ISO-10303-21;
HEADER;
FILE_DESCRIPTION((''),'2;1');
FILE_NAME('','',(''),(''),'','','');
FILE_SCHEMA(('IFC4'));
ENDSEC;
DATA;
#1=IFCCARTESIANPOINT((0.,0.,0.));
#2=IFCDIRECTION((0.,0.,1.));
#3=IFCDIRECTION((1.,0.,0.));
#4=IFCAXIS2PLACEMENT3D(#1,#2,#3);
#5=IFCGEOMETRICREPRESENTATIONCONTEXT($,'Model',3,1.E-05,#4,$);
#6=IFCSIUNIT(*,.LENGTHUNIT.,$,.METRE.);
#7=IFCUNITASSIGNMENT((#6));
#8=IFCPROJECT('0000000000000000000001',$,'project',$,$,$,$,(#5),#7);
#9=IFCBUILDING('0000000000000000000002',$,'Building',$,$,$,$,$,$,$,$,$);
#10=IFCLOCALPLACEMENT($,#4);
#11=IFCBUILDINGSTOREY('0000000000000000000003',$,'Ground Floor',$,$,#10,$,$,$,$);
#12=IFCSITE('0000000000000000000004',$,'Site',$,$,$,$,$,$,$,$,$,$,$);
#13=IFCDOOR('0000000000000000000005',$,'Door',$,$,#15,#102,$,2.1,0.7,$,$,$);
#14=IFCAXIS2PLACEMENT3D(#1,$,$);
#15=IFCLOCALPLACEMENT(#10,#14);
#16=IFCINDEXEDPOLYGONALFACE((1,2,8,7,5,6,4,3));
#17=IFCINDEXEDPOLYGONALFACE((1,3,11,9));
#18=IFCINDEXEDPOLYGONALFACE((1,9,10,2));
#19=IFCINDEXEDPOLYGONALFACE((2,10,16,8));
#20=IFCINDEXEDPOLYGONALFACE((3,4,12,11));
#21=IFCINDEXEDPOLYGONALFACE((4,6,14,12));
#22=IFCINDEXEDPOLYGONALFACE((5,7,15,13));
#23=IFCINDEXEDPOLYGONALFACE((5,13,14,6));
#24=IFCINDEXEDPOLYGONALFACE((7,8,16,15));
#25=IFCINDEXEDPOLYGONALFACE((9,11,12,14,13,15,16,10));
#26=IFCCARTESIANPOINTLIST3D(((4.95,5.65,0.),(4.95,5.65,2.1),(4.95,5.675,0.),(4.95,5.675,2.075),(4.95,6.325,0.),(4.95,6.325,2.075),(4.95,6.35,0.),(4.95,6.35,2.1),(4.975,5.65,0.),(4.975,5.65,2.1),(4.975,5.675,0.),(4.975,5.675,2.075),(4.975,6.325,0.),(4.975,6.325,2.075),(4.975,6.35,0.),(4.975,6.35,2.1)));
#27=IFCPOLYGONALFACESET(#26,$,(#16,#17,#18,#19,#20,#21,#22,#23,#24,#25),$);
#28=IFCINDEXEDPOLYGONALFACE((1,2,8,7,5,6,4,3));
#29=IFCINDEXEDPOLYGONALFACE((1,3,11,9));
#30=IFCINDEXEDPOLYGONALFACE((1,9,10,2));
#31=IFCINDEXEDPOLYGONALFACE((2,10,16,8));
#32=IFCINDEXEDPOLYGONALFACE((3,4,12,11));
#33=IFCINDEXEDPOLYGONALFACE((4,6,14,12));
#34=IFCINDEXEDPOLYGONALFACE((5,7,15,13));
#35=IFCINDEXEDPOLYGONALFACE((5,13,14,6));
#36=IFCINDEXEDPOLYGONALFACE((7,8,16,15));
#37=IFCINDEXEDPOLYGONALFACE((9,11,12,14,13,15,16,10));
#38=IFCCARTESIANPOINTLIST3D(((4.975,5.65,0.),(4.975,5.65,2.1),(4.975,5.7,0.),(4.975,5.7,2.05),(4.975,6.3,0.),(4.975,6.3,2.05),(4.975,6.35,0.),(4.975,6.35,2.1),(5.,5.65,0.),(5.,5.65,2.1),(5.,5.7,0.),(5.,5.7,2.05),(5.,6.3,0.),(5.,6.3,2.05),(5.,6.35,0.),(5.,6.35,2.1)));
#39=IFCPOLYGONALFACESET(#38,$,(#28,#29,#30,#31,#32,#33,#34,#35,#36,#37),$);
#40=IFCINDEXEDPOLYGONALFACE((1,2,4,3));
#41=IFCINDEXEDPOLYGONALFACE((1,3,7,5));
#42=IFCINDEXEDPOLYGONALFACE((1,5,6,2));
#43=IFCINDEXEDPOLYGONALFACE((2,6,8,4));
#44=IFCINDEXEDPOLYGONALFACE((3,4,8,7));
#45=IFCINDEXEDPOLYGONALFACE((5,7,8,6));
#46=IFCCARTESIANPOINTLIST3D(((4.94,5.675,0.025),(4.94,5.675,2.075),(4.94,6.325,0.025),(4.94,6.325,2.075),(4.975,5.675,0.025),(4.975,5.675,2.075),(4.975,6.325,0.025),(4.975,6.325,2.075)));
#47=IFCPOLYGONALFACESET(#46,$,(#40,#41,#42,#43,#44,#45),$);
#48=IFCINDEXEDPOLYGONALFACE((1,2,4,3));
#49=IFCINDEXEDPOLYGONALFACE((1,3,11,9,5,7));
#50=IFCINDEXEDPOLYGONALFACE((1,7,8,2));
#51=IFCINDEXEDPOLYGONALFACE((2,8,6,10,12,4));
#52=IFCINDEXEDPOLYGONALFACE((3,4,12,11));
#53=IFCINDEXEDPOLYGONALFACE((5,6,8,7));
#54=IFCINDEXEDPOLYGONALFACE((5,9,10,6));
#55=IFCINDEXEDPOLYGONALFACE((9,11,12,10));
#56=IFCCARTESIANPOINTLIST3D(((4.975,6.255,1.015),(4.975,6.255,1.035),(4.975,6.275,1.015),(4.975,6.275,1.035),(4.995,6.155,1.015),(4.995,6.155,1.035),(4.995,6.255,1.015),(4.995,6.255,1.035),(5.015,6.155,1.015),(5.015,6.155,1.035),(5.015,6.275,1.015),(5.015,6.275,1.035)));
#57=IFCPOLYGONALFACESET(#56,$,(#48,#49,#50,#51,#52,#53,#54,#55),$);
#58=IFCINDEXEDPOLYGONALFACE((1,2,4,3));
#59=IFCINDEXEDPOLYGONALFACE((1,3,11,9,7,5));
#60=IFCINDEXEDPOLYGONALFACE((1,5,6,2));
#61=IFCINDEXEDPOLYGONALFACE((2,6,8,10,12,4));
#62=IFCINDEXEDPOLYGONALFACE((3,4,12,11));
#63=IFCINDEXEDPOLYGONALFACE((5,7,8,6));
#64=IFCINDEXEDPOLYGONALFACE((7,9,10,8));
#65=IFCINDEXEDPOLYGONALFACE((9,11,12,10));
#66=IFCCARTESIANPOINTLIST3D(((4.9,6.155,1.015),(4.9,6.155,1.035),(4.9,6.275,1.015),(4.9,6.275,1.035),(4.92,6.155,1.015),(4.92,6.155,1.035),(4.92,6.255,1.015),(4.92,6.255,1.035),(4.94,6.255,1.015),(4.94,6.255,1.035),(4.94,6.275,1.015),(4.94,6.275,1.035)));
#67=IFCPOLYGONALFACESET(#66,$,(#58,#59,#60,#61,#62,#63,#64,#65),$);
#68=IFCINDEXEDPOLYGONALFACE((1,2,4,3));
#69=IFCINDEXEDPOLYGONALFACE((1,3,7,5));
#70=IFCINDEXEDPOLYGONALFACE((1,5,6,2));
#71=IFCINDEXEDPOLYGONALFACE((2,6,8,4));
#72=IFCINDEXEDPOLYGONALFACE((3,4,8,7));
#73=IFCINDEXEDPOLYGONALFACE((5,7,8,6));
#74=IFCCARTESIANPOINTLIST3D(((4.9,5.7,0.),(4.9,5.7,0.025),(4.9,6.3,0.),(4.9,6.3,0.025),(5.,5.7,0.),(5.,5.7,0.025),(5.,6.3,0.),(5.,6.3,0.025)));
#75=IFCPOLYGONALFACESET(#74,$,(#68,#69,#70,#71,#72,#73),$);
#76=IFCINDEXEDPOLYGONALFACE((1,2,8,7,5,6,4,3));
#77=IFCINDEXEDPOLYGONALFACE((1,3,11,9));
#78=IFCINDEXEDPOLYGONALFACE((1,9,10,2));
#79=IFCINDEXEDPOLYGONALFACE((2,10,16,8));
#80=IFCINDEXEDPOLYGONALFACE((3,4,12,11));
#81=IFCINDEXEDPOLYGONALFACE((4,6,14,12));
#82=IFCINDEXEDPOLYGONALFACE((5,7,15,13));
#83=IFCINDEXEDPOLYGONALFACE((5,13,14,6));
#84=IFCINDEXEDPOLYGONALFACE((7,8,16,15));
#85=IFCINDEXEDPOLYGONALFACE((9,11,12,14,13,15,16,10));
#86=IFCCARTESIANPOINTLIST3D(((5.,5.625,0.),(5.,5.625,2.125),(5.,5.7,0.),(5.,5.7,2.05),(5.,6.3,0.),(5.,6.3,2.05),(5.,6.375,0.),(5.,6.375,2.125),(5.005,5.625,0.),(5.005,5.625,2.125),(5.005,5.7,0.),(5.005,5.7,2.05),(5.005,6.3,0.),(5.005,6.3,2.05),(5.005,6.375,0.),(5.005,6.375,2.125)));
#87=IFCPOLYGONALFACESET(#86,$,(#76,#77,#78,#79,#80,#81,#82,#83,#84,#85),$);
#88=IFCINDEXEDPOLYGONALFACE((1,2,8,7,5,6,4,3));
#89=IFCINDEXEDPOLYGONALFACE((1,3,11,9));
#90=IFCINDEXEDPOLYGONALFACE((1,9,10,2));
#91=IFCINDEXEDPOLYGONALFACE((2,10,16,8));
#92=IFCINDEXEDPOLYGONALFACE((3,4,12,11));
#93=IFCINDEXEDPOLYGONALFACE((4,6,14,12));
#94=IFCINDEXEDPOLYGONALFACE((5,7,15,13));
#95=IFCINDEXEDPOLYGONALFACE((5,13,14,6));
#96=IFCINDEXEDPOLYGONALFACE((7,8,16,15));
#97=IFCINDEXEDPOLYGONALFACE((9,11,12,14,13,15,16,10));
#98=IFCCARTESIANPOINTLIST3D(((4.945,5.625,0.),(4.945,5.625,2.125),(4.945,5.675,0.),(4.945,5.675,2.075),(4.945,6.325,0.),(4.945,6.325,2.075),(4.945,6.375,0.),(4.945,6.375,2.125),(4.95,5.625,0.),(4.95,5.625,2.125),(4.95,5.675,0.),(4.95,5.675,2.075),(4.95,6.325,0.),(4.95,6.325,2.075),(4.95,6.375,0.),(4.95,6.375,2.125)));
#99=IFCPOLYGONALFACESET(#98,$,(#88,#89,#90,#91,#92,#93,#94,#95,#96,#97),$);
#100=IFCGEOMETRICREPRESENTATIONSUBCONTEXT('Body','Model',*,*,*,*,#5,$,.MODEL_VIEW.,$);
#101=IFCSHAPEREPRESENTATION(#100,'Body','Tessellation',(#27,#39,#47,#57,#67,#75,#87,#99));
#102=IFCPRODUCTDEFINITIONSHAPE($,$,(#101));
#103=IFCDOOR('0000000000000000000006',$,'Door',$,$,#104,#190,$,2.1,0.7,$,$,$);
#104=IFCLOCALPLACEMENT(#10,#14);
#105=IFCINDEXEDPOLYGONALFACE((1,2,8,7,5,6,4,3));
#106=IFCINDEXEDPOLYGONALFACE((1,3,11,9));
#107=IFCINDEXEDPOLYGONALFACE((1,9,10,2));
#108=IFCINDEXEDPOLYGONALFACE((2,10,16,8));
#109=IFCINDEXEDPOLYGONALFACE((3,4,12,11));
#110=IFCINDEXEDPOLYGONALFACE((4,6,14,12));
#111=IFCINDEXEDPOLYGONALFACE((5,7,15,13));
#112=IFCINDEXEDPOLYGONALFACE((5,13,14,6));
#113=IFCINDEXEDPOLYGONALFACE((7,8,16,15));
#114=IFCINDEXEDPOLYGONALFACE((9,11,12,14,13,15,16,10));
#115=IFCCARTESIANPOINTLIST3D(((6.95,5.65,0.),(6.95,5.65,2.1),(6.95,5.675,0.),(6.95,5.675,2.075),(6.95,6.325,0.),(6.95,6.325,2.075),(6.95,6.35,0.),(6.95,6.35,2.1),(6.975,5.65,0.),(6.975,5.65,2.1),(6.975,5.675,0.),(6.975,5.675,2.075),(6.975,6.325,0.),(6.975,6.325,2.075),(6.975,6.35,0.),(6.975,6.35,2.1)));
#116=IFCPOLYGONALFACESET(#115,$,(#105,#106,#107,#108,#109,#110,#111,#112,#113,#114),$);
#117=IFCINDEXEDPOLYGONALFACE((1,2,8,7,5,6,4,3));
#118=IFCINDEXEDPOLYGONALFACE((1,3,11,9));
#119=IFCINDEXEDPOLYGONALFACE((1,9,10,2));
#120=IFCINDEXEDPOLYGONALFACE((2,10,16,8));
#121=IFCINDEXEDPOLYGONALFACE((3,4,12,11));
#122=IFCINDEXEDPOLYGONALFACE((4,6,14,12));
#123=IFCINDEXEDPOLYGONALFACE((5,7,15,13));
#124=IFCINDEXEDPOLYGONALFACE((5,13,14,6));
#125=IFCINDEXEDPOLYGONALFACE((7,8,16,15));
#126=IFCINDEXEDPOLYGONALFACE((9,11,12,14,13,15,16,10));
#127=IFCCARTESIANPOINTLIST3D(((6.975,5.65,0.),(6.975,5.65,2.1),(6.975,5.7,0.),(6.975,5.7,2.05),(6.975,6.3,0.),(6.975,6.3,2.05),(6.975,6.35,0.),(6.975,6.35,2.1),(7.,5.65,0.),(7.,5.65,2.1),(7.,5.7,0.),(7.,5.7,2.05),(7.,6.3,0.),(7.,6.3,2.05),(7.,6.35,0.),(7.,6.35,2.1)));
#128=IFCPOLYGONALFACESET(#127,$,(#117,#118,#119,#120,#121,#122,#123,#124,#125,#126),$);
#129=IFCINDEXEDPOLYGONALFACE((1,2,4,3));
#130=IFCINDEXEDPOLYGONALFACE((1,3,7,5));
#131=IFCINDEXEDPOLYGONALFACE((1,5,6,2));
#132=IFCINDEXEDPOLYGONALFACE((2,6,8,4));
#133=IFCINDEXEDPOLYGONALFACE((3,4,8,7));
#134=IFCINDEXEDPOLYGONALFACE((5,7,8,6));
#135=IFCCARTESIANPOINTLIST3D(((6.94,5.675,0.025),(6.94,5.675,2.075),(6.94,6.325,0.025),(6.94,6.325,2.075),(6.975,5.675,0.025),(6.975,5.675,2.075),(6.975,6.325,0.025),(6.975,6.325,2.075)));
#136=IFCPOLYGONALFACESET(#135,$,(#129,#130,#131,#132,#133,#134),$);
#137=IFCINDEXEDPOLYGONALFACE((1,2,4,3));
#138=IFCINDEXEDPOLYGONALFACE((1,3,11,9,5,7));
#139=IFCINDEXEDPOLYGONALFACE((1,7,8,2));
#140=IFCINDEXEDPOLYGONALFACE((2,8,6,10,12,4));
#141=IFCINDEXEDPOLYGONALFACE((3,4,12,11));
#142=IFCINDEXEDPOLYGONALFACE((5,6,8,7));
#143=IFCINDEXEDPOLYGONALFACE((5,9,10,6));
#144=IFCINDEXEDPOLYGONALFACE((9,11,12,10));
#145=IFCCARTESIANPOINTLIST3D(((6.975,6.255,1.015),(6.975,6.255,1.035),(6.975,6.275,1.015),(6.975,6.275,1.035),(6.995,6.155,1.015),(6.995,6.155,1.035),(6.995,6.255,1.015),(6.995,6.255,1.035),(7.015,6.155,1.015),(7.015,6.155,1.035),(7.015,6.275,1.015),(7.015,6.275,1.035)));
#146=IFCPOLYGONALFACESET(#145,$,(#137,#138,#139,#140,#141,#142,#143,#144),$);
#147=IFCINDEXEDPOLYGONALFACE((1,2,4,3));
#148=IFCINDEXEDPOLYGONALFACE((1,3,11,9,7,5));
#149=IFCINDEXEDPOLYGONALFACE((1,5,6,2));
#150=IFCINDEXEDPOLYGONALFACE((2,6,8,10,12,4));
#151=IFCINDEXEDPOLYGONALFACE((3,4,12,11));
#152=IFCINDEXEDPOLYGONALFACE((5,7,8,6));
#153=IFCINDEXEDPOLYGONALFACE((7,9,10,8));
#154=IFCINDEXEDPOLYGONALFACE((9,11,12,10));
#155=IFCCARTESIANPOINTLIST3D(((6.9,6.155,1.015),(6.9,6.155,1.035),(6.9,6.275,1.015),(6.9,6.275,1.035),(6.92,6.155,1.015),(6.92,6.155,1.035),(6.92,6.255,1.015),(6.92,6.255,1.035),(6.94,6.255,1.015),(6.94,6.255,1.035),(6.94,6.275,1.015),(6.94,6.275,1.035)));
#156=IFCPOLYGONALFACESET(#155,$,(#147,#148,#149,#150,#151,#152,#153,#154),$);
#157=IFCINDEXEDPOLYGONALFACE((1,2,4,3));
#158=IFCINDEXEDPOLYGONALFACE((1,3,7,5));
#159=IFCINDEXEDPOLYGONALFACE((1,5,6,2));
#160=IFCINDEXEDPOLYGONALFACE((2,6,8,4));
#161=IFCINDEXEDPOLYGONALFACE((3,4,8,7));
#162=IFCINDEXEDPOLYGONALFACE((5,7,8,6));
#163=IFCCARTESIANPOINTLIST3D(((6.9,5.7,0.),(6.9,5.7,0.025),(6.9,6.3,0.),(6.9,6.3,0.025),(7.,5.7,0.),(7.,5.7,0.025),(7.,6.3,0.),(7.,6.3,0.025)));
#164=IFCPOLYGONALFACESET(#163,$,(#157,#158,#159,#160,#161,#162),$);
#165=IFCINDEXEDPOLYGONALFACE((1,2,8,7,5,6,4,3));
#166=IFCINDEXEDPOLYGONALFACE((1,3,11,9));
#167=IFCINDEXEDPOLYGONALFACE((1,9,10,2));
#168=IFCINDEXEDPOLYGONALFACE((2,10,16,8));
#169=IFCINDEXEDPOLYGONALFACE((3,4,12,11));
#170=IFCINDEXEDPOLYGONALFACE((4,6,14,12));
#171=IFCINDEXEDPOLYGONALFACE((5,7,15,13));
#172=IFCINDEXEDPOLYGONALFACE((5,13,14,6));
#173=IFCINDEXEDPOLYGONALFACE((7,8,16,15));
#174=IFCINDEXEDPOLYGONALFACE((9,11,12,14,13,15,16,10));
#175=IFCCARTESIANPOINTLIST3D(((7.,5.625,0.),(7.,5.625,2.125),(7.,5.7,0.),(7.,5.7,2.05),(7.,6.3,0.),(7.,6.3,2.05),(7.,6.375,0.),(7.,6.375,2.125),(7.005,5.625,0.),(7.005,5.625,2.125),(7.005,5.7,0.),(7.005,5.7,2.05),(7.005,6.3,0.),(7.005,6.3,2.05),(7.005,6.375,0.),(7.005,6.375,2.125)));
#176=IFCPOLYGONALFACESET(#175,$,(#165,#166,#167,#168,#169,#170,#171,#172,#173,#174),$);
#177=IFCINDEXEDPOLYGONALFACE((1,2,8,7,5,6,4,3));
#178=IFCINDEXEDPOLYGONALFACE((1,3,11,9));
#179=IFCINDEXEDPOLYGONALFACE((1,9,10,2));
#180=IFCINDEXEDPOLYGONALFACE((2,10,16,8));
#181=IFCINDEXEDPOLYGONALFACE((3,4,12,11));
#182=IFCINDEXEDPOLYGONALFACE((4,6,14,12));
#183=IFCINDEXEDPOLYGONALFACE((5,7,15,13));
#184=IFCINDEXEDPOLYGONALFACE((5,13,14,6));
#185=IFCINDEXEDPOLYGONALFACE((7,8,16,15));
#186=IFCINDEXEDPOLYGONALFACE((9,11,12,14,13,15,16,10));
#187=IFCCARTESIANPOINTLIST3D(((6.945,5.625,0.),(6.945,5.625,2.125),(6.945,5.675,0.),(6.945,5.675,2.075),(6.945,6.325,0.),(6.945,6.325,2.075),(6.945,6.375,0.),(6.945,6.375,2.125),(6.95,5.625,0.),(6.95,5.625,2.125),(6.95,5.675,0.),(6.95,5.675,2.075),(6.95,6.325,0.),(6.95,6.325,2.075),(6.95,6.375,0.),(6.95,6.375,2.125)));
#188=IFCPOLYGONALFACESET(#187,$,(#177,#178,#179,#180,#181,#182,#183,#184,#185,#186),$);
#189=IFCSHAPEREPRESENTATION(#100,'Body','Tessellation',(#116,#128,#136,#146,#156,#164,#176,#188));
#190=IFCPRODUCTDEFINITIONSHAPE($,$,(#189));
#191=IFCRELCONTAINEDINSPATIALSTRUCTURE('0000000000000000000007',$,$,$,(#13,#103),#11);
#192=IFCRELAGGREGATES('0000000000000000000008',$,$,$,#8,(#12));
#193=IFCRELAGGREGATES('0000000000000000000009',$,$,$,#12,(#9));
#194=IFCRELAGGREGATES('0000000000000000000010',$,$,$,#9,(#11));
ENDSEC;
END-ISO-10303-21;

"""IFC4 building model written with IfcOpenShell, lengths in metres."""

from ifc_helpers import new_model, si_unit, frame, origin_with_axes, place, context, subcontext, project, spatial, line, indexed_curve, outline, extrude, element, save


model = new_model("IFC4")

# Units and contexts
model_context = context("Model", 3, precision=1e-05, world=origin_with_axes())
body_context = subcontext(model_context, "Body", "Model", "MODEL_VIEW")
ifc_project = project(units=[si_unit("LENGTHUNIT", "METRE")], contexts=[model_context])

# Site, building, storey
site = spatial("IfcSite", under=ifc_project, Name="Site")
building = spatial("IfcBuilding", under=site, Name="Building")
storey_placement = place(None, origin_with_axes())
storey = spatial("IfcBuildingStorey", under=building, at=storey_placement, Name="Ground Floor")

# Doors
door_1_placement = place(storey_placement, frame((5.0, 5.65, 0.0), z_axis=(0.0, 0.0, 1.0), x_axis=(0.0, 1.0, 0.0)))
element("IfcDoor", 1, at=door_1_placement, inside=storey, Name="Door", OverallHeight=2.1, OverallWidth=0.7, context=body_context, shape_type="SweptSolid", body=[
    extrude(outline(indexed_curve([(0.0, 0.0), (0.0, 2.1), (0.7, 2.1), (0.7, 0.0), (0.675, 0.0), (0.675, 2.075), (0.025, 2.075), (0.025, 0.0)], segments=[line(1, 2, 3, 4, 5, 6, 7, 8, 1)])), frame((0.0, 0.025, 0.0), z_axis=(0.0, -1.0, 0.0), x_axis=(1.0, 0.0, 0.0)), (0.0, 0.0, -1.0), 0.025),
    extrude(outline(indexed_curve([(0.0, 0.0), (0.0, 2.1), (0.7, 2.1), (0.7, 0.0), (0.65, 0.0), (0.65, 2.05), (0.05, 2.05), (0.05, 0.0)], segments=[line(1, 2, 3, 4, 5, 6, 7, 8, 1)])), frame((0.0, 0.0, 0.0), z_axis=(0.0, -1.0, 0.0), x_axis=(1.0, 0.0, 0.0)), (0.0, 0.0, -1.0), 0.025),
    extrude(outline(indexed_curve([(0.0, 0.0), (0.65, 0.0), (0.65, 0.035), (0.0, 0.035)], segments=[line(1, 2, 3, 4, 1)])), frame((0.025, 0.025, 0.025), z_axis=(0.0, 0.0, 1.0), x_axis=(1.0, 0.0, 0.0)), (0.0, 0.0, 1.0), 2.05),
    extrude(outline(indexed_curve([(0.0, 0.0), (0.0, -0.04), (-0.12, -0.04), (-0.12, -0.02), (-0.02, -0.02), (-0.02, 0.0)], segments=[line(1, 2, 3, 4, 5, 6, 1)])), frame((0.625, 0.025, 1.015), z_axis=(0.0, 0.0, 1.0), x_axis=(1.0, 0.0, 0.0)), (0.0, 0.0, 1.0), 0.02),
    extrude(outline(indexed_curve([(0.0, 0.0), (0.0, 0.04), (-0.12, 0.04), (-0.12, 0.02), (-0.02, 0.02), (-0.02, 0.0)], segments=[line(1, 2, 3, 4, 5, 6, 1)])), frame((0.625, 0.06, 1.015), z_axis=(0.0, 0.0, 1.0), x_axis=(1.0, 0.0, 0.0)), (0.0, 0.0, 1.0), 0.02),
    extrude(outline(indexed_curve([(0.0, 0.0), (0.6, 0.0), (0.6, 0.1), (0.0, 0.1)], segments=[line(1, 2, 3, 4, 1)])), frame((0.05, 0.0, 0.0), z_axis=(0.0, 0.0, 1.0), x_axis=(1.0, 0.0, 0.0)), (0.0, 0.0, 1.0), 0.025),
    extrude(outline(indexed_curve([(0.0, 0.0), (0.0, 2.125), (0.75, 2.125), (0.75, 0.0), (0.675, 0.0), (0.675, 2.05), (0.075, 2.05), (0.075, 0.0)], segments=[line(1, 2, 3, 4, 5, 6, 7, 8, 1)])), frame((-0.025, -0.005, 0.0), z_axis=(0.0, -1.0, 0.0), x_axis=(1.0, 0.0, 0.0)), (0.0, 0.0, -1.0), 0.005),
    extrude(outline(indexed_curve([(0.0, 0.0), (0.0, 2.125), (0.75, 2.125), (0.75, 0.0), (0.7, 0.0), (0.7, 2.075), (0.05, 2.075), (0.05, 0.0)], segments=[line(1, 2, 3, 4, 5, 6, 7, 8, 1)])), frame((-0.025, 0.05, 0.0), z_axis=(0.0, -1.0, 0.0), x_axis=(1.0, 0.0, 0.0)), (0.0, 0.0, -1.0), 0.005),
])
door_2_placement = place(storey_placement, frame((7.0, 5.65, 0.0), z_axis=(0.0, 0.0, 1.0), x_axis=(0.0, 1.0, 0.0)))
element("IfcDoor", 2, at=door_2_placement, inside=storey, Name="Door", OverallHeight=2.1, OverallWidth=0.7, context=body_context, shape_type="SweptSolid", body=[
    extrude(outline(indexed_curve([(0.0, 0.0), (0.0, 2.1), (0.7, 2.1), (0.7, 0.0), (0.675, 0.0), (0.675, 2.075), (0.025, 2.075), (0.025, 0.0)], segments=[line(1, 2, 3, 4, 5, 6, 7, 8, 1)])), frame((0.0, 0.025, 0.0), z_axis=(0.0, -1.0, 0.0), x_axis=(1.0, 0.0, 0.0)), (0.0, 0.0, -1.0), 0.025),
    extrude(outline(indexed_curve([(0.0, 0.0), (0.0, 2.1), (0.7, 2.1), (0.7, 0.0), (0.65, 0.0), (0.65, 2.05), (0.05, 2.05), (0.05, 0.0)], segments=[line(1, 2, 3, 4, 5, 6, 7, 8, 1)])), frame((0.0, 0.0, 0.0), z_axis=(0.0, -1.0, 0.0), x_axis=(1.0, 0.0, 0.0)), (0.0, 0.0, -1.0), 0.025),
    extrude(outline(indexed_curve([(0.0, 0.0), (0.65, 0.0), (0.65, 0.035), (0.0, 0.035)], segments=[line(1, 2, 3, 4, 1)])), frame((0.025, 0.025, 0.025), z_axis=(0.0, 0.0, 1.0), x_axis=(1.0, 0.0, 0.0)), (0.0, 0.0, 1.0), 2.05),
    extrude(outline(indexed_curve([(0.0, 0.0), (0.0, -0.04), (-0.12, -0.04), (-0.12, -0.02), (-0.02, -0.02), (-0.02, 0.0)], segments=[line(1, 2, 3, 4, 5, 6, 1)])), frame((0.625, 0.025, 1.015), z_axis=(0.0, 0.0, 1.0), x_axis=(1.0, 0.0, 0.0)), (0.0, 0.0, 1.0), 0.02),
    extrude(outline(indexed_curve([(0.0, 0.0), (0.0, 0.04), (-0.12, 0.04), (-0.12, 0.02), (-0.02, 0.02), (-0.02, 0.0)], segments=[line(1, 2, 3, 4, 5, 6, 1)])), frame((0.625, 0.06, 1.015), z_axis=(0.0, 0.0, 1.0), x_axis=(1.0, 0.0, 0.0)), (0.0, 0.0, 1.0), 0.02),
    extrude(outline(indexed_curve([(0.0, 0.0), (0.6, 0.0), (0.6, 0.1), (0.0, 0.1)], segments=[line(1, 2, 3, 4, 1)])), frame((0.05, 0.0, 0.0), z_axis=(0.0, 0.0, 1.0), x_axis=(1.0, 0.0, 0.0)), (0.0, 0.0, 1.0), 0.025),
    extrude(outline(indexed_curve([(0.0, 0.0), (0.0, 2.125), (0.75, 2.125), (0.75, 0.0), (0.675, 0.0), (0.675, 2.05), (0.075, 2.05), (0.075, 0.0)], segments=[line(1, 2, 3, 4, 5, 6, 7, 8, 1)])), frame((-0.025, -0.005, 0.0), z_axis=(0.0, -1.0, 0.0), x_axis=(1.0, 0.0, 0.0)), (0.0, 0.0, -1.0), 0.005),
    extrude(outline(indexed_curve([(0.0, 0.0), (0.0, 2.125), (0.75, 2.125), (0.75, 0.0), (0.7, 0.0), (0.7, 2.075), (0.05, 2.075), (0.05, 0.0)], segments=[line(1, 2, 3, 4, 5, 6, 7, 8, 1)])), frame((-0.025, 0.05, 0.0), z_axis=(0.0, -1.0, 0.0), x_axis=(1.0, 0.0, 0.0)), (0.0, 0.0, -1.0), 0.005),
])

save(model, "model.ifc")
